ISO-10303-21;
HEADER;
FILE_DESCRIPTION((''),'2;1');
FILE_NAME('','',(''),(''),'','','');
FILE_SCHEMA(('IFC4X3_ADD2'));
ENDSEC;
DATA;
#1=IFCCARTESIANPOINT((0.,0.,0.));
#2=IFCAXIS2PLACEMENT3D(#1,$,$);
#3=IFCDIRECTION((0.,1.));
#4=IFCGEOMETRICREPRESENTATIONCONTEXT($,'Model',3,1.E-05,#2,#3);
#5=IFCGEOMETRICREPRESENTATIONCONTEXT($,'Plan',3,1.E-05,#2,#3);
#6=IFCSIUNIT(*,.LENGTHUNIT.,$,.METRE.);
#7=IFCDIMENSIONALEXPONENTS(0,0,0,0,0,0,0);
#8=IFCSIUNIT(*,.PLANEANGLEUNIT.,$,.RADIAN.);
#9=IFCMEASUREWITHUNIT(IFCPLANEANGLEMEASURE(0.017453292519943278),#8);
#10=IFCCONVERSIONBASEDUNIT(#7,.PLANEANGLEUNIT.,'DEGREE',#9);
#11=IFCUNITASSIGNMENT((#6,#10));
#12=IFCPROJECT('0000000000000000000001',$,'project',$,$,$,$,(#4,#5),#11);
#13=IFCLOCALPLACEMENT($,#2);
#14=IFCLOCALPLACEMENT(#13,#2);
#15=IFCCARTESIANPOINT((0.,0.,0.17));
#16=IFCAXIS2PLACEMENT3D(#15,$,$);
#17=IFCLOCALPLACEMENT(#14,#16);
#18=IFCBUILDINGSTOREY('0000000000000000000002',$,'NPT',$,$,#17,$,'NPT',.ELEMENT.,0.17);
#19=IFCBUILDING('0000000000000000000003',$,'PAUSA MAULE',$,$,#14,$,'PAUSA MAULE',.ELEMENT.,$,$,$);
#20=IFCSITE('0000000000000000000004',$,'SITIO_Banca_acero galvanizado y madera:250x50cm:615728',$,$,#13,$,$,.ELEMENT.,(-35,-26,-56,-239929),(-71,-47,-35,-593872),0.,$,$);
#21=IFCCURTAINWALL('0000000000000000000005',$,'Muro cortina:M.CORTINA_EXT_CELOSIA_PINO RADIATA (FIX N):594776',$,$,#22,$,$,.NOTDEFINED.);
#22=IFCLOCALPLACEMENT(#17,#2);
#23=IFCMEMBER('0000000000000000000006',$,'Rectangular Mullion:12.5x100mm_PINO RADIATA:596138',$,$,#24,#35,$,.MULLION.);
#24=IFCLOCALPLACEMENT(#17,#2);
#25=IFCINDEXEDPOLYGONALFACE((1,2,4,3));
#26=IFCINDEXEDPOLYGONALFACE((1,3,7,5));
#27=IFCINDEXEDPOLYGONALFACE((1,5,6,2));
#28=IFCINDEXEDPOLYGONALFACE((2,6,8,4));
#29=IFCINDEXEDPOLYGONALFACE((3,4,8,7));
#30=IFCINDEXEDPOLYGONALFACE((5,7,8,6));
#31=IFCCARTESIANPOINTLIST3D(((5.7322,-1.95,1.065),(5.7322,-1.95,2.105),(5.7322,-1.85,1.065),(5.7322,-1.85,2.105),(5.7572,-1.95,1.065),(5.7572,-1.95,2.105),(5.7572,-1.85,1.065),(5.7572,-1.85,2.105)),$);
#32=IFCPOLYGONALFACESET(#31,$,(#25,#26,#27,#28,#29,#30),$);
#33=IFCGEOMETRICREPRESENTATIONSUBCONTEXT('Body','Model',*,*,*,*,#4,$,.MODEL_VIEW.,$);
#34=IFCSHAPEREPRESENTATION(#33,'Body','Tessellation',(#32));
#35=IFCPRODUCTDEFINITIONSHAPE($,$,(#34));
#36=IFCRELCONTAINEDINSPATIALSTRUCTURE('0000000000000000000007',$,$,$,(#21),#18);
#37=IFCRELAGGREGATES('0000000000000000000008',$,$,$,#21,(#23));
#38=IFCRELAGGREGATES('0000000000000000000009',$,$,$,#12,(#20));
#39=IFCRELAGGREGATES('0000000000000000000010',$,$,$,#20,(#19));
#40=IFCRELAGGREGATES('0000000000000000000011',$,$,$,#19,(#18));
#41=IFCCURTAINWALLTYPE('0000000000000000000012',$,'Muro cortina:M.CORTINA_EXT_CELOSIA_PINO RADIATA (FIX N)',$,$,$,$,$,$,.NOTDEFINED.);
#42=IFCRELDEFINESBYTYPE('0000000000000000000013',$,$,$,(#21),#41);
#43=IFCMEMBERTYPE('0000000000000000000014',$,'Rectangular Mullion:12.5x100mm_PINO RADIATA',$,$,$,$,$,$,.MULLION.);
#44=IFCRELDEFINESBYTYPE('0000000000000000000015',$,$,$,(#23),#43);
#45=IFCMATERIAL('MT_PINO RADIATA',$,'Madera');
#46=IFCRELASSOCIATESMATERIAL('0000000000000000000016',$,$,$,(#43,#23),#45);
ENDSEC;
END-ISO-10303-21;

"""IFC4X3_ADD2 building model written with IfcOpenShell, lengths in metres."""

from ifc_helpers import new_model, entity, si_unit, converted_unit, direction, frame, frame_2d, origin, origin_2d_with_axis, place, context, subcontext, project, spatial, rectangle, extrude, source, transform, mapped, material, material_profile, profile_set, profile_usage, type_object, type_shapes, element, aggregate, save


model = new_model("IFC4X3_ADD2")

# Units and contexts
model_context = context("Model", 3, precision=1e-05, world=origin(), true_north=direction((0.0, 1.0)))
plan_context = context("Plan", 3, precision=1e-05, world=origin(), true_north=direction((0.0, 1.0)))
body_context = subcontext(model_context, "Body", "Model", "MODEL_VIEW")
ifc_project = project(units=[si_unit("LENGTHUNIT", "METRE"), converted_unit("PLANEANGLEUNIT", "DEGREE", entity("IfcPlaneAngleMeasure", 0.017453292519943278), si_unit("PLANEANGLEUNIT", "RADIAN"), dimensions=[0, 0, 0, 0, 0, 0, 0])], contexts=[model_context, plan_context])

# Site, building, storey
site_placement = place(None, origin())
site = spatial("IfcSite", under=ifc_project, at=site_placement, Name="SITIO_Banca_acero galvanizado y madera:250x50cm:615728", CompositionType="ELEMENT", RefLatitude=(-35, -26, -56, -239929), RefLongitude=(-71, -47, -35, -593872), RefElevation=0.0)
building_placement = place(site_placement, origin())
building = spatial("IfcBuilding", under=site, at=building_placement, Name="PAUSA MAULE", LongName="PAUSA MAULE", CompositionType="ELEMENT")
storey_placement = place(building_placement, frame((0.0, 0.0, 0.17)))
storey = spatial("IfcBuildingStorey", under=building, at=storey_placement, Name="NPT", LongName="NPT", CompositionType="ELEMENT", Elevation=0.17)

# Curtain wall
curtain_wall_type = type_object("IfcCurtainWallType", Name="Muro cortina:M.CORTINA_EXT_CELOSIA_PINO RADIATA (FIX N)", PredefinedType="NOTDEFINED")
curtain_wall_1_placement = place(storey_placement, frame((0.0, 0.0, -0.17)))
curtain_wall_1 = element("IfcCurtainWall", 1, at=curtain_wall_1_placement, inside=storey, type_object=curtain_wall_type, Name="Muro cortina:M.CORTINA_EXT_CELOSIA_PINO RADIATA (FIX N):594776", PredefinedType="NOTDEFINED")
ifc_material = material(Name="MT_PINO RADIATA", Category="Madera")
ifc_material_profile = material_profile(ifc_material, rectangle(XDim=0.025, YDim=0.1, at=frame_2d((0.0, 0.0), x_axis=(1.0, 0.0))), Name="12.5x100mm_PINO RADIATA")
ifc_profile_set = profile_set([ifc_material_profile], Name="12.5x100mm_PINO RADIATA")
ifc_profile_usage = profile_usage(ifc_profile_set)

# Member
member_type_1 = type_object("IfcMemberType", Name="Rectangular Mullion:12.5x100mm_PINO RADIATA", PredefinedType="MULLION", material=ifc_profile_set)
shared_shape_1 = source(origin(), body_context, "Body", "SweptSolid", [
    extrude(rectangle(XDim=0.025, YDim=0.1, at=origin_2d_with_axis()), frame((0.0, 0.0, -1.04), z_axis=(0.0, 0.0, 1.0), x_axis=(-1.0, 0.0, 0.0)), (0.0, 0.0, 1.0), 1.04),
])
type_shapes(member_type_1, [shared_shape_1])
member_1_placement = place(curtain_wall_1_placement, frame((5.7447, -1.9, 1.235), z_axis=(0.0, 0.0, -1.0), x_axis=(1.0, 0.0, 0.0)))
member_1 = element("IfcMember", 2, at=member_1_placement, type_object=member_type_1, material=ifc_profile_usage, Name="Rectangular Mullion:12.5x100mm_PINO RADIATA:596138", PredefinedType="MULLION", context=body_context, shape_type="MappedRepresentation", body=[
    mapped(shared_shape_1, transform((0.0, 0.0, 0.0), scale=1.0)),
])
aggregate(curtain_wall_1, [member_1])

save(model, "model.ifc")
